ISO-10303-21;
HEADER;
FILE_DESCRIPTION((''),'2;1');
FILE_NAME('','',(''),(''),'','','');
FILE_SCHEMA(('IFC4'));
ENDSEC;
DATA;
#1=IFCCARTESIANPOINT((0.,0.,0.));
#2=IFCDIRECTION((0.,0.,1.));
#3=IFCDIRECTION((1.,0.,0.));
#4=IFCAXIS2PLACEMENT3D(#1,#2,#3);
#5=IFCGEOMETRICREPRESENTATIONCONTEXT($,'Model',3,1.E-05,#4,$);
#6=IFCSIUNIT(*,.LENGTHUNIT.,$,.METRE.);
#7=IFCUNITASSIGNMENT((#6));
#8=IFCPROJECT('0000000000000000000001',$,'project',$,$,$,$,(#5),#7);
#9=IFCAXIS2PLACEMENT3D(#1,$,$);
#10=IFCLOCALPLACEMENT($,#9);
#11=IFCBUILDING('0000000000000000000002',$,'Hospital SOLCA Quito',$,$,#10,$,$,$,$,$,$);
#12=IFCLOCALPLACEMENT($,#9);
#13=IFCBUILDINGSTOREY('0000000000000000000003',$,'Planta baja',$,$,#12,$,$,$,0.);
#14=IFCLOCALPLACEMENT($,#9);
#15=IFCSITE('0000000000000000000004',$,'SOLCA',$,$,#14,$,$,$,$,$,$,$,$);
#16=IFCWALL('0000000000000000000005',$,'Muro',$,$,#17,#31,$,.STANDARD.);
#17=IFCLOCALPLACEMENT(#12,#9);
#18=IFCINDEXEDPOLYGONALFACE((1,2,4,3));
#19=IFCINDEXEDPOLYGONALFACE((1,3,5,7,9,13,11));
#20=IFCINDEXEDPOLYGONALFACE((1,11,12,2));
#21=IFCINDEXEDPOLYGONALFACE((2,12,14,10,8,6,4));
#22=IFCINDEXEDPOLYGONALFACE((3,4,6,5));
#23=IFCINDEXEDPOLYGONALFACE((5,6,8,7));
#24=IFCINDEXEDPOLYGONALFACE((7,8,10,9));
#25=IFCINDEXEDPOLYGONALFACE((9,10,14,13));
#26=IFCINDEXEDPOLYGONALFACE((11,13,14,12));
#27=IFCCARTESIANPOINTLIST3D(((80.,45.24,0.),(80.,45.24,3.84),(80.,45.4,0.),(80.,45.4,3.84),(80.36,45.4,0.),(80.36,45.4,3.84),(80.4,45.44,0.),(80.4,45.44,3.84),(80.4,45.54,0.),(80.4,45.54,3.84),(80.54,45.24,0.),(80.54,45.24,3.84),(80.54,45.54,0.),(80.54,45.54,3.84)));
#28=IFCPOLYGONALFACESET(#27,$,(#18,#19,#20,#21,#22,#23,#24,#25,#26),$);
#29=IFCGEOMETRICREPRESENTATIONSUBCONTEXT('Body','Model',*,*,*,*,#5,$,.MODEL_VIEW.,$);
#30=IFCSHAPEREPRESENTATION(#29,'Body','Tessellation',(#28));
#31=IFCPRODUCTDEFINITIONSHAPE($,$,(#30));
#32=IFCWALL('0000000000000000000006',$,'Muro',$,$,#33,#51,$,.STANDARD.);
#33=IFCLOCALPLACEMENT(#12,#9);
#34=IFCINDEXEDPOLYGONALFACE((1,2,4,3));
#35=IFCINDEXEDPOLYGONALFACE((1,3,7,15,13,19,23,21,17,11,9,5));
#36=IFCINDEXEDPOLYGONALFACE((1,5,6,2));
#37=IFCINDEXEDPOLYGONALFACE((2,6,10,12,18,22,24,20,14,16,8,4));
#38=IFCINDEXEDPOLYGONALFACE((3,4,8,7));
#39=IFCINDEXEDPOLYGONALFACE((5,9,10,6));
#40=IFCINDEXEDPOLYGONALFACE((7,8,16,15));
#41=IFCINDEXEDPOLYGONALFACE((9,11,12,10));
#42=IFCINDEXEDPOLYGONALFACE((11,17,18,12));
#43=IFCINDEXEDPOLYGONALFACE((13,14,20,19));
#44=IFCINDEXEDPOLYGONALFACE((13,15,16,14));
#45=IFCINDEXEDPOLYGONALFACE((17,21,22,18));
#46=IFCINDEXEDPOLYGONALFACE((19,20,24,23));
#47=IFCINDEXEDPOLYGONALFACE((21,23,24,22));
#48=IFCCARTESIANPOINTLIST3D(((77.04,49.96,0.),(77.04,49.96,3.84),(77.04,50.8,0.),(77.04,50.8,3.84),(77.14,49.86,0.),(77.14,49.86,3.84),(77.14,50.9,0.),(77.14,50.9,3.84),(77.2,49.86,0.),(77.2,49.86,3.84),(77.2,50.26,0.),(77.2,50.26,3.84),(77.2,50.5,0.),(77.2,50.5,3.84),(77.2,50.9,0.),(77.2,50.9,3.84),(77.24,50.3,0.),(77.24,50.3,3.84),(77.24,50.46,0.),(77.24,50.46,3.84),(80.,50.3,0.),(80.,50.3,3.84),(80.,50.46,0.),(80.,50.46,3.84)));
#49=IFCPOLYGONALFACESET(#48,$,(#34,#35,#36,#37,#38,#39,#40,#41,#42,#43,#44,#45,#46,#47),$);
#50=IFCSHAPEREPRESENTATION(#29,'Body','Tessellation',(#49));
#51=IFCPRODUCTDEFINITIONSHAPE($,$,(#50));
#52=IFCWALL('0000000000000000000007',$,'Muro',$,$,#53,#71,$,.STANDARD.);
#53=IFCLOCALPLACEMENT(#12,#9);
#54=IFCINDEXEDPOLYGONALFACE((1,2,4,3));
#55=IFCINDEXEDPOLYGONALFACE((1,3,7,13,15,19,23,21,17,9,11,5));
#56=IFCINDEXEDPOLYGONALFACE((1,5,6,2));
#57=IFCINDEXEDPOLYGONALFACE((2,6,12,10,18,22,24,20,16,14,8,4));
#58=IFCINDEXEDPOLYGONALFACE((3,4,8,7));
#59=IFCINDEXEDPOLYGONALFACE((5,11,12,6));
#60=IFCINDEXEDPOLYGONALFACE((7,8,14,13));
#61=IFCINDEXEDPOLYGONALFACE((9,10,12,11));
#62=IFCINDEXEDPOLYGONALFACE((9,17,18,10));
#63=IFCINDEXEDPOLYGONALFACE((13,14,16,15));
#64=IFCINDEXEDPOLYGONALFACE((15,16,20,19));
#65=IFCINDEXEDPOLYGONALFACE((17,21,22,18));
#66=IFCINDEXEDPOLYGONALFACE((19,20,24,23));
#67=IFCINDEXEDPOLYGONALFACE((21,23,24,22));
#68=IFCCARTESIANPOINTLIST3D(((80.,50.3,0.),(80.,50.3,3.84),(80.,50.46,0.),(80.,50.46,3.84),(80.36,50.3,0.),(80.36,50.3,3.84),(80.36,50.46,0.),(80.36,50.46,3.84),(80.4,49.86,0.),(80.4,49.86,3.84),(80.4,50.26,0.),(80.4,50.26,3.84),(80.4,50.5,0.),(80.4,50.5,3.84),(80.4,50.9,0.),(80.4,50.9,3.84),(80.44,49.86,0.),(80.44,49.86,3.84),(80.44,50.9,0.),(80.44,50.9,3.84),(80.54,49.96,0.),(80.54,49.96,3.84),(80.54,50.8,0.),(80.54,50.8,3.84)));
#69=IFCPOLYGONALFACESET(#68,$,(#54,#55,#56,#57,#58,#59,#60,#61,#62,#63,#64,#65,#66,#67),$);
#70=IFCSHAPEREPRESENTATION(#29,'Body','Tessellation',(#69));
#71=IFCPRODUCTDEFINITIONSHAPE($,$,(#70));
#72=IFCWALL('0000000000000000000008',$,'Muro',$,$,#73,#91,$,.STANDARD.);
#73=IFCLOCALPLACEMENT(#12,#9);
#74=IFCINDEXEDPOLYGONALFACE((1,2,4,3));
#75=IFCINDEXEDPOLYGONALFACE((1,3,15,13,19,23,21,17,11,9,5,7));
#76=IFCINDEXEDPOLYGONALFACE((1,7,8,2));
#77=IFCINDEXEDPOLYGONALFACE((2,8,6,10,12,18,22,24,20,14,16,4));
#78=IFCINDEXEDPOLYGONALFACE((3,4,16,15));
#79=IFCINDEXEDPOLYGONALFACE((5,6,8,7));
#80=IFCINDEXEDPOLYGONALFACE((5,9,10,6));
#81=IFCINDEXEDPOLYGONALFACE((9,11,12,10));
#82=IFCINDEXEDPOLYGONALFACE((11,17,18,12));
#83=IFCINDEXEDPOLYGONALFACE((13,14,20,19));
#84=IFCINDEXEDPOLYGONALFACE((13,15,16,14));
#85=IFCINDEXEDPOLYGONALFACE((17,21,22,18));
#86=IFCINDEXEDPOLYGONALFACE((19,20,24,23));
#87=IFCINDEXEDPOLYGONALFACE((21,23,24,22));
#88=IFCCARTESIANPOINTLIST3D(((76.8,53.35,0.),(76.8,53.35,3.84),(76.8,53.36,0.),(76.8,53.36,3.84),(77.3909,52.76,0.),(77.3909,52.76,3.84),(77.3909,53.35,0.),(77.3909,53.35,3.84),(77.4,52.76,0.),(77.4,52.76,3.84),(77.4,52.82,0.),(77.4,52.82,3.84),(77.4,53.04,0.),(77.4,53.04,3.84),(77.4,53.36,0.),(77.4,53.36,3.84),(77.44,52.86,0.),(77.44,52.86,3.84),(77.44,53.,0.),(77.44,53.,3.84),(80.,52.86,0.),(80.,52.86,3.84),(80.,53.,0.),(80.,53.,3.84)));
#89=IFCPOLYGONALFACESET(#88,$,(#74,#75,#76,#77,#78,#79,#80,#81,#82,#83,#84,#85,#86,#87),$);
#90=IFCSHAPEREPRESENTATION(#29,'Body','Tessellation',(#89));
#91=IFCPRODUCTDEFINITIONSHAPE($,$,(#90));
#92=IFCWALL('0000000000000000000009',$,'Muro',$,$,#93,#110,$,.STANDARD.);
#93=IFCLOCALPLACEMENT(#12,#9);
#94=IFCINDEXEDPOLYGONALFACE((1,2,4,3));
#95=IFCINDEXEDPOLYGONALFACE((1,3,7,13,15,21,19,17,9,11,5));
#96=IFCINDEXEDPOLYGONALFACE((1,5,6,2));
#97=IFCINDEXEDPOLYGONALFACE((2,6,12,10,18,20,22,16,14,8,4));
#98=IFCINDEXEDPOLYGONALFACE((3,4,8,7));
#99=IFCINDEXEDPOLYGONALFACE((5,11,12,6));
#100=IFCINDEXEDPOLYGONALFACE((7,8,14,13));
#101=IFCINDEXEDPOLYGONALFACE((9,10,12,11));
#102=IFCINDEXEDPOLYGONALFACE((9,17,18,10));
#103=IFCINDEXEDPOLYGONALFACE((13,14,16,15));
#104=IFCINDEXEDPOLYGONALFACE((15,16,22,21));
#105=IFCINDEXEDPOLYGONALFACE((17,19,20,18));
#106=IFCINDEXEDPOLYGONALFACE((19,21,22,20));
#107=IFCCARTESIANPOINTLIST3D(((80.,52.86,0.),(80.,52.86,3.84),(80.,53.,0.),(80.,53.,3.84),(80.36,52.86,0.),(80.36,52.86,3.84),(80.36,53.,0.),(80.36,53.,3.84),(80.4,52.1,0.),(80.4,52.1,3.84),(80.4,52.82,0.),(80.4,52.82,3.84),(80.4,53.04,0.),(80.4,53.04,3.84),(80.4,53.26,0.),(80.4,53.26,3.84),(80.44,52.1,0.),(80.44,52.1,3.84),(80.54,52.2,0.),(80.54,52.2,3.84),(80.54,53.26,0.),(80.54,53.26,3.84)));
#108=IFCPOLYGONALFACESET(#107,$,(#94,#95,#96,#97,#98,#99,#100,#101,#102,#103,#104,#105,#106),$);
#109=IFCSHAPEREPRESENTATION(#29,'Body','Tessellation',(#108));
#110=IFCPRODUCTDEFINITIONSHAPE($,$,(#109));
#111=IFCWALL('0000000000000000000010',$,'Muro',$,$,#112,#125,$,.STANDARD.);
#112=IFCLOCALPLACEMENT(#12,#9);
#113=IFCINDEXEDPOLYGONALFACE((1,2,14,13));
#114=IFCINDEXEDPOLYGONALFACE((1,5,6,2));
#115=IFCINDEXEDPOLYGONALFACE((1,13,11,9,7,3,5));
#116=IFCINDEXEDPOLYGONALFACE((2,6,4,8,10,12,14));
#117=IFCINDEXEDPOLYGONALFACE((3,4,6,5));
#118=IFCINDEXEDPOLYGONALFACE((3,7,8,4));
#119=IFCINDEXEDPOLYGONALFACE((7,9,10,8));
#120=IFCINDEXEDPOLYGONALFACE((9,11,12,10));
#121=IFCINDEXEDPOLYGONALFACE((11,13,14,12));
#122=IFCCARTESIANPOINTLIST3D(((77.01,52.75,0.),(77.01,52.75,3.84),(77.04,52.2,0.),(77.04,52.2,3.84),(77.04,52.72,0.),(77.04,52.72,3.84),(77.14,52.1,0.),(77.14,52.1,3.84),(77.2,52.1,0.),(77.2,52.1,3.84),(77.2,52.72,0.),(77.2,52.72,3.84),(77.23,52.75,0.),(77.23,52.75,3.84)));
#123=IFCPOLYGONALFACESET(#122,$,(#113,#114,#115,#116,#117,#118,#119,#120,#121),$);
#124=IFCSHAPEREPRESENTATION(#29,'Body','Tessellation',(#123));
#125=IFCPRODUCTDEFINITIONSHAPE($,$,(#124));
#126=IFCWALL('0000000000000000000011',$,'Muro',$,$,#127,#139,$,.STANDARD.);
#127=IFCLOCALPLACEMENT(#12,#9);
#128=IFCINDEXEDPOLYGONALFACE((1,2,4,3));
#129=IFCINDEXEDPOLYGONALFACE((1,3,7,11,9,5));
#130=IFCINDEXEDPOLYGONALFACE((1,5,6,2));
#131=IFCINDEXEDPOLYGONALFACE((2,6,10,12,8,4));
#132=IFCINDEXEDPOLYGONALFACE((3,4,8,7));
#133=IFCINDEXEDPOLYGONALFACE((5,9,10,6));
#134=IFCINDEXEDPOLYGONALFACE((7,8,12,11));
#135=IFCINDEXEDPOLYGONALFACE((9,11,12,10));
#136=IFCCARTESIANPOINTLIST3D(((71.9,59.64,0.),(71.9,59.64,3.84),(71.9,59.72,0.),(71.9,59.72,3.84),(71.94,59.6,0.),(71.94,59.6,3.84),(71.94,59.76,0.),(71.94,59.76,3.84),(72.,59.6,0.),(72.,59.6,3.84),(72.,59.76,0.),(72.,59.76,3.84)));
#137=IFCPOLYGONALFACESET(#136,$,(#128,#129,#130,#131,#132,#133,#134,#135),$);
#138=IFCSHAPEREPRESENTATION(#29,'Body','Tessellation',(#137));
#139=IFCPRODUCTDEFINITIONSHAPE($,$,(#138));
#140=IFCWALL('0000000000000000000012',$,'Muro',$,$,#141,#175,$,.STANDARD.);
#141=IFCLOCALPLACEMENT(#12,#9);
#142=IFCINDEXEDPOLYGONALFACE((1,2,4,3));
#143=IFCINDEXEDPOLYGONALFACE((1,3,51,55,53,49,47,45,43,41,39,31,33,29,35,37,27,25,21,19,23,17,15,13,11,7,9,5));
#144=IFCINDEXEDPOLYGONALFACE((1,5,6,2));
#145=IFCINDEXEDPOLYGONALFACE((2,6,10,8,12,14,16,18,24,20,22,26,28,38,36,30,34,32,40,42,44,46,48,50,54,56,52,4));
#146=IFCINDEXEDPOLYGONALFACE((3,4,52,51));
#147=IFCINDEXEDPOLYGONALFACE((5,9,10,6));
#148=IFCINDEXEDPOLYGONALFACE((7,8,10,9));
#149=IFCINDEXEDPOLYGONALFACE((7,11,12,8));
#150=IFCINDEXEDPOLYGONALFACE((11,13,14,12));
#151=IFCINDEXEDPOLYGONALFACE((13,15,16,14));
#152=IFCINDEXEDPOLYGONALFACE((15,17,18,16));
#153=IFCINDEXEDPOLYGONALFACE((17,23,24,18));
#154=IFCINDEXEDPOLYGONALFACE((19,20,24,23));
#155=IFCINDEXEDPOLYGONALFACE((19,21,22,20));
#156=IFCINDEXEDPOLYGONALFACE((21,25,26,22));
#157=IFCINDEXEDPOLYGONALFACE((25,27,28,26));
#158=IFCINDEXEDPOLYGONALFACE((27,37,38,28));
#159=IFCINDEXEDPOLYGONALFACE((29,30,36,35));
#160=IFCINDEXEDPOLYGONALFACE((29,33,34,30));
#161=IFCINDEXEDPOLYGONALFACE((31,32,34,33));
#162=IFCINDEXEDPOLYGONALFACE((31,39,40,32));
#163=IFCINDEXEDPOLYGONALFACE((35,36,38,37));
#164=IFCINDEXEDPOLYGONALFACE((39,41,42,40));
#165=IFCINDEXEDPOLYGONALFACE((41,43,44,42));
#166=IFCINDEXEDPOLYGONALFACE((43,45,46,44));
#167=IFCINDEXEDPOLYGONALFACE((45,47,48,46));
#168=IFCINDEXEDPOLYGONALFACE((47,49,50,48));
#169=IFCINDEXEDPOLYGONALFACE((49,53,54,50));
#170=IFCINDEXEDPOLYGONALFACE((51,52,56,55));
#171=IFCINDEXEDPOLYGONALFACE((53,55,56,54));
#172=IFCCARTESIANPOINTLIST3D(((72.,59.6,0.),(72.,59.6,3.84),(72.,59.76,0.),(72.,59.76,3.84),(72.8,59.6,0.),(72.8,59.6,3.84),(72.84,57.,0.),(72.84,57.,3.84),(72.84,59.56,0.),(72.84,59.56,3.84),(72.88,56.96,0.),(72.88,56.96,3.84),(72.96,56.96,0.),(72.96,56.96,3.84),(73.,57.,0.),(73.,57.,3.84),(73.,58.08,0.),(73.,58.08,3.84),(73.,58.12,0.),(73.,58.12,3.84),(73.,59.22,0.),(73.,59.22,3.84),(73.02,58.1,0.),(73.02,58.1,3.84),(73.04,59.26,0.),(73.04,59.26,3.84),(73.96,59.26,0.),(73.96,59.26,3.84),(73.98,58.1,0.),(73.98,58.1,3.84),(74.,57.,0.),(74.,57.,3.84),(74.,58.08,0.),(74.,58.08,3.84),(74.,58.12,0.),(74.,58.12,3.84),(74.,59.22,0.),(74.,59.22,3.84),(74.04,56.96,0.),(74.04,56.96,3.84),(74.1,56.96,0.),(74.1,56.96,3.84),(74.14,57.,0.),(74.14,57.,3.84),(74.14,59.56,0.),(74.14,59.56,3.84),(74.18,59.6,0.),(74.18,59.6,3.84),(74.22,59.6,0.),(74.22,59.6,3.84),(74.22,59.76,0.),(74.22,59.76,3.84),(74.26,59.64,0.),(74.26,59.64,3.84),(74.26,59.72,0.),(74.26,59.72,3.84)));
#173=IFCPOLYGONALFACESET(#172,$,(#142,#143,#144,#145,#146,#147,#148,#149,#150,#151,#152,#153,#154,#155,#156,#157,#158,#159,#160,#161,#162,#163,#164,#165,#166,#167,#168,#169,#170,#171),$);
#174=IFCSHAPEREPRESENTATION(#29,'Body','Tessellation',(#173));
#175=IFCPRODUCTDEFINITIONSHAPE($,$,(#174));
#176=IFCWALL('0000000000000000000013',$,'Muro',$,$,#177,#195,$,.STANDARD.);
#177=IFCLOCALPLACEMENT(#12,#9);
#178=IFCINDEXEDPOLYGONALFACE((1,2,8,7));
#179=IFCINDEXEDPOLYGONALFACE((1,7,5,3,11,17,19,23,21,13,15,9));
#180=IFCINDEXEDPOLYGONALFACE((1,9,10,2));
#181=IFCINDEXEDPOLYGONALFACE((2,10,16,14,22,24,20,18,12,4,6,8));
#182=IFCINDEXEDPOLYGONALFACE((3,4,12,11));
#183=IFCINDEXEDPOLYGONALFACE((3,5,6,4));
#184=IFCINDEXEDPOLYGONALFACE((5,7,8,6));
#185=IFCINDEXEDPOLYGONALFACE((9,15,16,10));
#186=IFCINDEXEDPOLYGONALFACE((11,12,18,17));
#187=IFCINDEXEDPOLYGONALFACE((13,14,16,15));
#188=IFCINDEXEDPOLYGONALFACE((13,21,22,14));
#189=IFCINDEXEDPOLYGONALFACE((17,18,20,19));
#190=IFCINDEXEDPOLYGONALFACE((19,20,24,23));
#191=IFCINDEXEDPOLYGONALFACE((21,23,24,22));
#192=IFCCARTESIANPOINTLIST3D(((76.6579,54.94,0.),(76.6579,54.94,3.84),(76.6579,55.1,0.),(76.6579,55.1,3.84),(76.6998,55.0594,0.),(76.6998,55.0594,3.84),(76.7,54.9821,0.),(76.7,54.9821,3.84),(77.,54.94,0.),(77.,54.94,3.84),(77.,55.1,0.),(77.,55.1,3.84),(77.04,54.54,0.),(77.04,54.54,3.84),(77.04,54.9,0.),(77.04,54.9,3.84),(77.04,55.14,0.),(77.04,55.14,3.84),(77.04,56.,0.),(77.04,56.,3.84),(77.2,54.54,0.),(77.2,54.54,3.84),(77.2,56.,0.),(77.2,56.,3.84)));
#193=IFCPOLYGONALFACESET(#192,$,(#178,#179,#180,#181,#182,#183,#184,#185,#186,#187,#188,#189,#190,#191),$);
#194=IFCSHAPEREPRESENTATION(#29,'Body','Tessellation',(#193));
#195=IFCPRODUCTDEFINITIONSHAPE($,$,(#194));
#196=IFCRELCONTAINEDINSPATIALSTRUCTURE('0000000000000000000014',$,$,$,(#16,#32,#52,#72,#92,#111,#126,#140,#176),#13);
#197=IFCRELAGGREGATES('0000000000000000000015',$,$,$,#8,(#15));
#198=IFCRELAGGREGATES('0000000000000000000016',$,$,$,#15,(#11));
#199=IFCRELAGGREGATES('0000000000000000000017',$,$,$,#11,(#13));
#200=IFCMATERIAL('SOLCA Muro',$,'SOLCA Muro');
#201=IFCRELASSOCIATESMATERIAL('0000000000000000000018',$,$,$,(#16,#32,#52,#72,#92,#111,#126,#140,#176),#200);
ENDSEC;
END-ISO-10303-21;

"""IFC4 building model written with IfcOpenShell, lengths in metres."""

from ifc_helpers import new_model, si_unit, origin, origin_with_axes, place, context, subcontext, project, spatial, polyline, outline, extrude, material, element, save


model = new_model("IFC4")

# Units and contexts
model_context = context("Model", 3, precision=1e-05, world=origin_with_axes())
body_context = subcontext(model_context, "Body", "Model", "MODEL_VIEW")
ifc_project = project(units=[si_unit("LENGTHUNIT", "METRE")], contexts=[model_context])

# Site, building, storey
site_placement = place(None, origin())
site = spatial("IfcSite", under=ifc_project, at=site_placement, Name="SOLCA")
building_placement = place(None, origin())
building = spatial("IfcBuilding", under=site, at=building_placement, Name="Hospital SOLCA Quito")
storey_placement = place(None, origin())
storey = spatial("IfcBuildingStorey", under=building, at=storey_placement, Name="Planta baja", Elevation=0.0)

# Walls
ifc_material = material(Name="SOLCA Muro", Category="SOLCA Muro")
wall_1_placement = place(storey_placement, origin_with_axes())
element("IfcWall", 1, at=wall_1_placement, inside=storey, material=ifc_material, Name="Muro", PredefinedType="STANDARD", context=body_context, shape_type="SweptSolid", body=[
    extrude(outline(polyline([(80.36, 45.4), (80.4, 45.44), (80.4, 45.54), (80.54, 45.54), (80.54, 45.24), (80.0, 45.24), (80.0, 45.4), (80.36, 45.4)])), origin_with_axes(), (0.0, 0.0, 1.0), 3.84),
])
wall_2_placement = place(storey_placement, origin_with_axes())
element("IfcWall", 2, at=wall_2_placement, inside=storey, material=ifc_material, Name="Muro", PredefinedType="STANDARD", context=body_context, shape_type="SweptSolid", body=[
    extrude(outline(polyline([(77.04, 50.8), (77.14, 50.9), (77.2, 50.9), (77.2, 50.5), (77.24, 50.46), (80.0, 50.46), (80.0, 50.3), (77.24, 50.3), (77.2, 50.26), (77.2, 49.86), (77.14, 49.86), (77.04, 49.96), (77.04, 50.8)])), origin_with_axes(), (0.0, 0.0, 1.0), 3.84),
])
wall_3_placement = place(storey_placement, origin_with_axes())
element("IfcWall", 3, at=wall_3_placement, inside=storey, material=ifc_material, Name="Muro", PredefinedType="STANDARD", context=body_context, shape_type="SweptSolid", body=[
    extrude(outline(polyline([(80.36, 50.46), (80.4, 50.5), (80.4, 50.9), (80.44, 50.9), (80.54, 50.8), (80.54, 49.96), (80.44, 49.86), (80.4, 49.86), (80.4, 50.26), (80.36, 50.3), (80.0, 50.3), (80.0, 50.46), (80.36, 50.46)])), origin_with_axes(), (0.0, 0.0, 1.0), 3.84),
])
wall_4_placement = place(storey_placement, origin_with_axes())
element("IfcWall", 4, at=wall_4_placement, inside=storey, material=ifc_material, Name="Muro", PredefinedType="STANDARD", context=body_context, shape_type="SweptSolid", body=[
    extrude(outline(polyline([(76.8, 53.36), (77.4, 53.36), (77.4, 53.04), (77.44, 53.0), (80.0, 53.0), (80.0, 52.86), (77.44, 52.86), (77.4, 52.82), (77.4, 52.76), (77.3909, 52.76), (77.3909, 53.35), (76.8, 53.35), (76.8, 53.36)])), origin_with_axes(), (0.0, 0.0, 1.0), 3.84),
])
wall_5_placement = place(storey_placement, origin_with_axes())
element("IfcWall", 5, at=wall_5_placement, inside=storey, material=ifc_material, Name="Muro", PredefinedType="STANDARD", context=body_context, shape_type="SweptSolid", body=[
    extrude(outline(polyline([(80.36, 53.0), (80.4, 53.04), (80.4, 53.26), (80.54, 53.26), (80.54, 52.2), (80.44, 52.1), (80.4, 52.1), (80.4, 52.82), (80.36, 52.86), (80.0, 52.86), (80.0, 53.0), (80.36, 53.0)])), origin_with_axes(), (0.0, 0.0, 1.0), 3.84),
])
wall_6_placement = place(storey_placement, origin_with_axes())
element("IfcWall", 6, at=wall_6_placement, inside=storey, material=ifc_material, Name="Muro", PredefinedType="STANDARD", context=body_context, shape_type="SweptSolid", body=[
    extrude(outline(polyline([(77.04, 52.72), (77.01, 52.75), (77.23, 52.75), (77.2, 52.72), (77.2, 52.1), (77.14, 52.1), (77.04, 52.2), (77.04, 52.72)])), origin_with_axes(), (0.0, 0.0, 1.0), 3.84),
])
wall_7_placement = place(storey_placement, origin_with_axes())
element("IfcWall", 7, at=wall_7_placement, inside=storey, material=ifc_material, Name="Muro", PredefinedType="STANDARD", context=body_context, shape_type="SweptSolid", body=[
    extrude(outline(polyline([(71.94, 59.6), (71.9, 59.64), (71.9, 59.72), (71.94, 59.76), (72.0, 59.76), (72.0, 59.6), (71.94, 59.6)])), origin_with_axes(), (0.0, 0.0, 1.0), 3.84),
])
wall_8_placement = place(storey_placement, origin_with_axes())
element("IfcWall", 8, at=wall_8_placement, inside=storey, material=ifc_material, Name="Muro", PredefinedType="STANDARD", context=body_context, shape_type="SweptSolid", body=[
    extrude(outline(polyline([(73.0, 58.12), (73.02, 58.1), (73.0, 58.08), (73.0, 57.0), (72.96, 56.96), (72.88, 56.96), (72.84, 57.0), (72.84, 59.56), (72.8, 59.6), (72.0, 59.6), (72.0, 59.76), (74.22, 59.76), (74.26, 59.72), (74.26, 59.64), (74.22, 59.6), (74.18, 59.6), (74.14, 59.56), (74.14, 57.0), (74.1, 56.96), (74.04, 56.96), (74.0, 57.0), (74.0, 58.08), (73.98, 58.1), (74.0, 58.12), (74.0, 59.22), (73.96, 59.26), (73.04, 59.26), (73.0, 59.22), (73.0, 58.12)])), origin_with_axes(), (0.0, 0.0, 1.0), 3.84),
])
wall_9_placement = place(storey_placement, origin_with_axes())
element("IfcWall", 9, at=wall_9_placement, inside=storey, material=ifc_material, Name="Muro", PredefinedType="STANDARD", context=body_context, shape_type="SweptSolid", body=[
    extrude(outline(polyline([(76.6579, 54.94), (76.7, 54.9821), (76.6998, 55.0594), (76.6579, 55.1), (77.0, 55.1), (77.04, 55.14), (77.04, 56.0), (77.2, 56.0), (77.2, 54.54), (77.04, 54.54), (77.04, 54.9), (77.0, 54.94), (76.6579, 54.94)])), origin_with_axes(), (0.0, 0.0, 1.0), 3.84),
])

save(model, "model.ifc")
